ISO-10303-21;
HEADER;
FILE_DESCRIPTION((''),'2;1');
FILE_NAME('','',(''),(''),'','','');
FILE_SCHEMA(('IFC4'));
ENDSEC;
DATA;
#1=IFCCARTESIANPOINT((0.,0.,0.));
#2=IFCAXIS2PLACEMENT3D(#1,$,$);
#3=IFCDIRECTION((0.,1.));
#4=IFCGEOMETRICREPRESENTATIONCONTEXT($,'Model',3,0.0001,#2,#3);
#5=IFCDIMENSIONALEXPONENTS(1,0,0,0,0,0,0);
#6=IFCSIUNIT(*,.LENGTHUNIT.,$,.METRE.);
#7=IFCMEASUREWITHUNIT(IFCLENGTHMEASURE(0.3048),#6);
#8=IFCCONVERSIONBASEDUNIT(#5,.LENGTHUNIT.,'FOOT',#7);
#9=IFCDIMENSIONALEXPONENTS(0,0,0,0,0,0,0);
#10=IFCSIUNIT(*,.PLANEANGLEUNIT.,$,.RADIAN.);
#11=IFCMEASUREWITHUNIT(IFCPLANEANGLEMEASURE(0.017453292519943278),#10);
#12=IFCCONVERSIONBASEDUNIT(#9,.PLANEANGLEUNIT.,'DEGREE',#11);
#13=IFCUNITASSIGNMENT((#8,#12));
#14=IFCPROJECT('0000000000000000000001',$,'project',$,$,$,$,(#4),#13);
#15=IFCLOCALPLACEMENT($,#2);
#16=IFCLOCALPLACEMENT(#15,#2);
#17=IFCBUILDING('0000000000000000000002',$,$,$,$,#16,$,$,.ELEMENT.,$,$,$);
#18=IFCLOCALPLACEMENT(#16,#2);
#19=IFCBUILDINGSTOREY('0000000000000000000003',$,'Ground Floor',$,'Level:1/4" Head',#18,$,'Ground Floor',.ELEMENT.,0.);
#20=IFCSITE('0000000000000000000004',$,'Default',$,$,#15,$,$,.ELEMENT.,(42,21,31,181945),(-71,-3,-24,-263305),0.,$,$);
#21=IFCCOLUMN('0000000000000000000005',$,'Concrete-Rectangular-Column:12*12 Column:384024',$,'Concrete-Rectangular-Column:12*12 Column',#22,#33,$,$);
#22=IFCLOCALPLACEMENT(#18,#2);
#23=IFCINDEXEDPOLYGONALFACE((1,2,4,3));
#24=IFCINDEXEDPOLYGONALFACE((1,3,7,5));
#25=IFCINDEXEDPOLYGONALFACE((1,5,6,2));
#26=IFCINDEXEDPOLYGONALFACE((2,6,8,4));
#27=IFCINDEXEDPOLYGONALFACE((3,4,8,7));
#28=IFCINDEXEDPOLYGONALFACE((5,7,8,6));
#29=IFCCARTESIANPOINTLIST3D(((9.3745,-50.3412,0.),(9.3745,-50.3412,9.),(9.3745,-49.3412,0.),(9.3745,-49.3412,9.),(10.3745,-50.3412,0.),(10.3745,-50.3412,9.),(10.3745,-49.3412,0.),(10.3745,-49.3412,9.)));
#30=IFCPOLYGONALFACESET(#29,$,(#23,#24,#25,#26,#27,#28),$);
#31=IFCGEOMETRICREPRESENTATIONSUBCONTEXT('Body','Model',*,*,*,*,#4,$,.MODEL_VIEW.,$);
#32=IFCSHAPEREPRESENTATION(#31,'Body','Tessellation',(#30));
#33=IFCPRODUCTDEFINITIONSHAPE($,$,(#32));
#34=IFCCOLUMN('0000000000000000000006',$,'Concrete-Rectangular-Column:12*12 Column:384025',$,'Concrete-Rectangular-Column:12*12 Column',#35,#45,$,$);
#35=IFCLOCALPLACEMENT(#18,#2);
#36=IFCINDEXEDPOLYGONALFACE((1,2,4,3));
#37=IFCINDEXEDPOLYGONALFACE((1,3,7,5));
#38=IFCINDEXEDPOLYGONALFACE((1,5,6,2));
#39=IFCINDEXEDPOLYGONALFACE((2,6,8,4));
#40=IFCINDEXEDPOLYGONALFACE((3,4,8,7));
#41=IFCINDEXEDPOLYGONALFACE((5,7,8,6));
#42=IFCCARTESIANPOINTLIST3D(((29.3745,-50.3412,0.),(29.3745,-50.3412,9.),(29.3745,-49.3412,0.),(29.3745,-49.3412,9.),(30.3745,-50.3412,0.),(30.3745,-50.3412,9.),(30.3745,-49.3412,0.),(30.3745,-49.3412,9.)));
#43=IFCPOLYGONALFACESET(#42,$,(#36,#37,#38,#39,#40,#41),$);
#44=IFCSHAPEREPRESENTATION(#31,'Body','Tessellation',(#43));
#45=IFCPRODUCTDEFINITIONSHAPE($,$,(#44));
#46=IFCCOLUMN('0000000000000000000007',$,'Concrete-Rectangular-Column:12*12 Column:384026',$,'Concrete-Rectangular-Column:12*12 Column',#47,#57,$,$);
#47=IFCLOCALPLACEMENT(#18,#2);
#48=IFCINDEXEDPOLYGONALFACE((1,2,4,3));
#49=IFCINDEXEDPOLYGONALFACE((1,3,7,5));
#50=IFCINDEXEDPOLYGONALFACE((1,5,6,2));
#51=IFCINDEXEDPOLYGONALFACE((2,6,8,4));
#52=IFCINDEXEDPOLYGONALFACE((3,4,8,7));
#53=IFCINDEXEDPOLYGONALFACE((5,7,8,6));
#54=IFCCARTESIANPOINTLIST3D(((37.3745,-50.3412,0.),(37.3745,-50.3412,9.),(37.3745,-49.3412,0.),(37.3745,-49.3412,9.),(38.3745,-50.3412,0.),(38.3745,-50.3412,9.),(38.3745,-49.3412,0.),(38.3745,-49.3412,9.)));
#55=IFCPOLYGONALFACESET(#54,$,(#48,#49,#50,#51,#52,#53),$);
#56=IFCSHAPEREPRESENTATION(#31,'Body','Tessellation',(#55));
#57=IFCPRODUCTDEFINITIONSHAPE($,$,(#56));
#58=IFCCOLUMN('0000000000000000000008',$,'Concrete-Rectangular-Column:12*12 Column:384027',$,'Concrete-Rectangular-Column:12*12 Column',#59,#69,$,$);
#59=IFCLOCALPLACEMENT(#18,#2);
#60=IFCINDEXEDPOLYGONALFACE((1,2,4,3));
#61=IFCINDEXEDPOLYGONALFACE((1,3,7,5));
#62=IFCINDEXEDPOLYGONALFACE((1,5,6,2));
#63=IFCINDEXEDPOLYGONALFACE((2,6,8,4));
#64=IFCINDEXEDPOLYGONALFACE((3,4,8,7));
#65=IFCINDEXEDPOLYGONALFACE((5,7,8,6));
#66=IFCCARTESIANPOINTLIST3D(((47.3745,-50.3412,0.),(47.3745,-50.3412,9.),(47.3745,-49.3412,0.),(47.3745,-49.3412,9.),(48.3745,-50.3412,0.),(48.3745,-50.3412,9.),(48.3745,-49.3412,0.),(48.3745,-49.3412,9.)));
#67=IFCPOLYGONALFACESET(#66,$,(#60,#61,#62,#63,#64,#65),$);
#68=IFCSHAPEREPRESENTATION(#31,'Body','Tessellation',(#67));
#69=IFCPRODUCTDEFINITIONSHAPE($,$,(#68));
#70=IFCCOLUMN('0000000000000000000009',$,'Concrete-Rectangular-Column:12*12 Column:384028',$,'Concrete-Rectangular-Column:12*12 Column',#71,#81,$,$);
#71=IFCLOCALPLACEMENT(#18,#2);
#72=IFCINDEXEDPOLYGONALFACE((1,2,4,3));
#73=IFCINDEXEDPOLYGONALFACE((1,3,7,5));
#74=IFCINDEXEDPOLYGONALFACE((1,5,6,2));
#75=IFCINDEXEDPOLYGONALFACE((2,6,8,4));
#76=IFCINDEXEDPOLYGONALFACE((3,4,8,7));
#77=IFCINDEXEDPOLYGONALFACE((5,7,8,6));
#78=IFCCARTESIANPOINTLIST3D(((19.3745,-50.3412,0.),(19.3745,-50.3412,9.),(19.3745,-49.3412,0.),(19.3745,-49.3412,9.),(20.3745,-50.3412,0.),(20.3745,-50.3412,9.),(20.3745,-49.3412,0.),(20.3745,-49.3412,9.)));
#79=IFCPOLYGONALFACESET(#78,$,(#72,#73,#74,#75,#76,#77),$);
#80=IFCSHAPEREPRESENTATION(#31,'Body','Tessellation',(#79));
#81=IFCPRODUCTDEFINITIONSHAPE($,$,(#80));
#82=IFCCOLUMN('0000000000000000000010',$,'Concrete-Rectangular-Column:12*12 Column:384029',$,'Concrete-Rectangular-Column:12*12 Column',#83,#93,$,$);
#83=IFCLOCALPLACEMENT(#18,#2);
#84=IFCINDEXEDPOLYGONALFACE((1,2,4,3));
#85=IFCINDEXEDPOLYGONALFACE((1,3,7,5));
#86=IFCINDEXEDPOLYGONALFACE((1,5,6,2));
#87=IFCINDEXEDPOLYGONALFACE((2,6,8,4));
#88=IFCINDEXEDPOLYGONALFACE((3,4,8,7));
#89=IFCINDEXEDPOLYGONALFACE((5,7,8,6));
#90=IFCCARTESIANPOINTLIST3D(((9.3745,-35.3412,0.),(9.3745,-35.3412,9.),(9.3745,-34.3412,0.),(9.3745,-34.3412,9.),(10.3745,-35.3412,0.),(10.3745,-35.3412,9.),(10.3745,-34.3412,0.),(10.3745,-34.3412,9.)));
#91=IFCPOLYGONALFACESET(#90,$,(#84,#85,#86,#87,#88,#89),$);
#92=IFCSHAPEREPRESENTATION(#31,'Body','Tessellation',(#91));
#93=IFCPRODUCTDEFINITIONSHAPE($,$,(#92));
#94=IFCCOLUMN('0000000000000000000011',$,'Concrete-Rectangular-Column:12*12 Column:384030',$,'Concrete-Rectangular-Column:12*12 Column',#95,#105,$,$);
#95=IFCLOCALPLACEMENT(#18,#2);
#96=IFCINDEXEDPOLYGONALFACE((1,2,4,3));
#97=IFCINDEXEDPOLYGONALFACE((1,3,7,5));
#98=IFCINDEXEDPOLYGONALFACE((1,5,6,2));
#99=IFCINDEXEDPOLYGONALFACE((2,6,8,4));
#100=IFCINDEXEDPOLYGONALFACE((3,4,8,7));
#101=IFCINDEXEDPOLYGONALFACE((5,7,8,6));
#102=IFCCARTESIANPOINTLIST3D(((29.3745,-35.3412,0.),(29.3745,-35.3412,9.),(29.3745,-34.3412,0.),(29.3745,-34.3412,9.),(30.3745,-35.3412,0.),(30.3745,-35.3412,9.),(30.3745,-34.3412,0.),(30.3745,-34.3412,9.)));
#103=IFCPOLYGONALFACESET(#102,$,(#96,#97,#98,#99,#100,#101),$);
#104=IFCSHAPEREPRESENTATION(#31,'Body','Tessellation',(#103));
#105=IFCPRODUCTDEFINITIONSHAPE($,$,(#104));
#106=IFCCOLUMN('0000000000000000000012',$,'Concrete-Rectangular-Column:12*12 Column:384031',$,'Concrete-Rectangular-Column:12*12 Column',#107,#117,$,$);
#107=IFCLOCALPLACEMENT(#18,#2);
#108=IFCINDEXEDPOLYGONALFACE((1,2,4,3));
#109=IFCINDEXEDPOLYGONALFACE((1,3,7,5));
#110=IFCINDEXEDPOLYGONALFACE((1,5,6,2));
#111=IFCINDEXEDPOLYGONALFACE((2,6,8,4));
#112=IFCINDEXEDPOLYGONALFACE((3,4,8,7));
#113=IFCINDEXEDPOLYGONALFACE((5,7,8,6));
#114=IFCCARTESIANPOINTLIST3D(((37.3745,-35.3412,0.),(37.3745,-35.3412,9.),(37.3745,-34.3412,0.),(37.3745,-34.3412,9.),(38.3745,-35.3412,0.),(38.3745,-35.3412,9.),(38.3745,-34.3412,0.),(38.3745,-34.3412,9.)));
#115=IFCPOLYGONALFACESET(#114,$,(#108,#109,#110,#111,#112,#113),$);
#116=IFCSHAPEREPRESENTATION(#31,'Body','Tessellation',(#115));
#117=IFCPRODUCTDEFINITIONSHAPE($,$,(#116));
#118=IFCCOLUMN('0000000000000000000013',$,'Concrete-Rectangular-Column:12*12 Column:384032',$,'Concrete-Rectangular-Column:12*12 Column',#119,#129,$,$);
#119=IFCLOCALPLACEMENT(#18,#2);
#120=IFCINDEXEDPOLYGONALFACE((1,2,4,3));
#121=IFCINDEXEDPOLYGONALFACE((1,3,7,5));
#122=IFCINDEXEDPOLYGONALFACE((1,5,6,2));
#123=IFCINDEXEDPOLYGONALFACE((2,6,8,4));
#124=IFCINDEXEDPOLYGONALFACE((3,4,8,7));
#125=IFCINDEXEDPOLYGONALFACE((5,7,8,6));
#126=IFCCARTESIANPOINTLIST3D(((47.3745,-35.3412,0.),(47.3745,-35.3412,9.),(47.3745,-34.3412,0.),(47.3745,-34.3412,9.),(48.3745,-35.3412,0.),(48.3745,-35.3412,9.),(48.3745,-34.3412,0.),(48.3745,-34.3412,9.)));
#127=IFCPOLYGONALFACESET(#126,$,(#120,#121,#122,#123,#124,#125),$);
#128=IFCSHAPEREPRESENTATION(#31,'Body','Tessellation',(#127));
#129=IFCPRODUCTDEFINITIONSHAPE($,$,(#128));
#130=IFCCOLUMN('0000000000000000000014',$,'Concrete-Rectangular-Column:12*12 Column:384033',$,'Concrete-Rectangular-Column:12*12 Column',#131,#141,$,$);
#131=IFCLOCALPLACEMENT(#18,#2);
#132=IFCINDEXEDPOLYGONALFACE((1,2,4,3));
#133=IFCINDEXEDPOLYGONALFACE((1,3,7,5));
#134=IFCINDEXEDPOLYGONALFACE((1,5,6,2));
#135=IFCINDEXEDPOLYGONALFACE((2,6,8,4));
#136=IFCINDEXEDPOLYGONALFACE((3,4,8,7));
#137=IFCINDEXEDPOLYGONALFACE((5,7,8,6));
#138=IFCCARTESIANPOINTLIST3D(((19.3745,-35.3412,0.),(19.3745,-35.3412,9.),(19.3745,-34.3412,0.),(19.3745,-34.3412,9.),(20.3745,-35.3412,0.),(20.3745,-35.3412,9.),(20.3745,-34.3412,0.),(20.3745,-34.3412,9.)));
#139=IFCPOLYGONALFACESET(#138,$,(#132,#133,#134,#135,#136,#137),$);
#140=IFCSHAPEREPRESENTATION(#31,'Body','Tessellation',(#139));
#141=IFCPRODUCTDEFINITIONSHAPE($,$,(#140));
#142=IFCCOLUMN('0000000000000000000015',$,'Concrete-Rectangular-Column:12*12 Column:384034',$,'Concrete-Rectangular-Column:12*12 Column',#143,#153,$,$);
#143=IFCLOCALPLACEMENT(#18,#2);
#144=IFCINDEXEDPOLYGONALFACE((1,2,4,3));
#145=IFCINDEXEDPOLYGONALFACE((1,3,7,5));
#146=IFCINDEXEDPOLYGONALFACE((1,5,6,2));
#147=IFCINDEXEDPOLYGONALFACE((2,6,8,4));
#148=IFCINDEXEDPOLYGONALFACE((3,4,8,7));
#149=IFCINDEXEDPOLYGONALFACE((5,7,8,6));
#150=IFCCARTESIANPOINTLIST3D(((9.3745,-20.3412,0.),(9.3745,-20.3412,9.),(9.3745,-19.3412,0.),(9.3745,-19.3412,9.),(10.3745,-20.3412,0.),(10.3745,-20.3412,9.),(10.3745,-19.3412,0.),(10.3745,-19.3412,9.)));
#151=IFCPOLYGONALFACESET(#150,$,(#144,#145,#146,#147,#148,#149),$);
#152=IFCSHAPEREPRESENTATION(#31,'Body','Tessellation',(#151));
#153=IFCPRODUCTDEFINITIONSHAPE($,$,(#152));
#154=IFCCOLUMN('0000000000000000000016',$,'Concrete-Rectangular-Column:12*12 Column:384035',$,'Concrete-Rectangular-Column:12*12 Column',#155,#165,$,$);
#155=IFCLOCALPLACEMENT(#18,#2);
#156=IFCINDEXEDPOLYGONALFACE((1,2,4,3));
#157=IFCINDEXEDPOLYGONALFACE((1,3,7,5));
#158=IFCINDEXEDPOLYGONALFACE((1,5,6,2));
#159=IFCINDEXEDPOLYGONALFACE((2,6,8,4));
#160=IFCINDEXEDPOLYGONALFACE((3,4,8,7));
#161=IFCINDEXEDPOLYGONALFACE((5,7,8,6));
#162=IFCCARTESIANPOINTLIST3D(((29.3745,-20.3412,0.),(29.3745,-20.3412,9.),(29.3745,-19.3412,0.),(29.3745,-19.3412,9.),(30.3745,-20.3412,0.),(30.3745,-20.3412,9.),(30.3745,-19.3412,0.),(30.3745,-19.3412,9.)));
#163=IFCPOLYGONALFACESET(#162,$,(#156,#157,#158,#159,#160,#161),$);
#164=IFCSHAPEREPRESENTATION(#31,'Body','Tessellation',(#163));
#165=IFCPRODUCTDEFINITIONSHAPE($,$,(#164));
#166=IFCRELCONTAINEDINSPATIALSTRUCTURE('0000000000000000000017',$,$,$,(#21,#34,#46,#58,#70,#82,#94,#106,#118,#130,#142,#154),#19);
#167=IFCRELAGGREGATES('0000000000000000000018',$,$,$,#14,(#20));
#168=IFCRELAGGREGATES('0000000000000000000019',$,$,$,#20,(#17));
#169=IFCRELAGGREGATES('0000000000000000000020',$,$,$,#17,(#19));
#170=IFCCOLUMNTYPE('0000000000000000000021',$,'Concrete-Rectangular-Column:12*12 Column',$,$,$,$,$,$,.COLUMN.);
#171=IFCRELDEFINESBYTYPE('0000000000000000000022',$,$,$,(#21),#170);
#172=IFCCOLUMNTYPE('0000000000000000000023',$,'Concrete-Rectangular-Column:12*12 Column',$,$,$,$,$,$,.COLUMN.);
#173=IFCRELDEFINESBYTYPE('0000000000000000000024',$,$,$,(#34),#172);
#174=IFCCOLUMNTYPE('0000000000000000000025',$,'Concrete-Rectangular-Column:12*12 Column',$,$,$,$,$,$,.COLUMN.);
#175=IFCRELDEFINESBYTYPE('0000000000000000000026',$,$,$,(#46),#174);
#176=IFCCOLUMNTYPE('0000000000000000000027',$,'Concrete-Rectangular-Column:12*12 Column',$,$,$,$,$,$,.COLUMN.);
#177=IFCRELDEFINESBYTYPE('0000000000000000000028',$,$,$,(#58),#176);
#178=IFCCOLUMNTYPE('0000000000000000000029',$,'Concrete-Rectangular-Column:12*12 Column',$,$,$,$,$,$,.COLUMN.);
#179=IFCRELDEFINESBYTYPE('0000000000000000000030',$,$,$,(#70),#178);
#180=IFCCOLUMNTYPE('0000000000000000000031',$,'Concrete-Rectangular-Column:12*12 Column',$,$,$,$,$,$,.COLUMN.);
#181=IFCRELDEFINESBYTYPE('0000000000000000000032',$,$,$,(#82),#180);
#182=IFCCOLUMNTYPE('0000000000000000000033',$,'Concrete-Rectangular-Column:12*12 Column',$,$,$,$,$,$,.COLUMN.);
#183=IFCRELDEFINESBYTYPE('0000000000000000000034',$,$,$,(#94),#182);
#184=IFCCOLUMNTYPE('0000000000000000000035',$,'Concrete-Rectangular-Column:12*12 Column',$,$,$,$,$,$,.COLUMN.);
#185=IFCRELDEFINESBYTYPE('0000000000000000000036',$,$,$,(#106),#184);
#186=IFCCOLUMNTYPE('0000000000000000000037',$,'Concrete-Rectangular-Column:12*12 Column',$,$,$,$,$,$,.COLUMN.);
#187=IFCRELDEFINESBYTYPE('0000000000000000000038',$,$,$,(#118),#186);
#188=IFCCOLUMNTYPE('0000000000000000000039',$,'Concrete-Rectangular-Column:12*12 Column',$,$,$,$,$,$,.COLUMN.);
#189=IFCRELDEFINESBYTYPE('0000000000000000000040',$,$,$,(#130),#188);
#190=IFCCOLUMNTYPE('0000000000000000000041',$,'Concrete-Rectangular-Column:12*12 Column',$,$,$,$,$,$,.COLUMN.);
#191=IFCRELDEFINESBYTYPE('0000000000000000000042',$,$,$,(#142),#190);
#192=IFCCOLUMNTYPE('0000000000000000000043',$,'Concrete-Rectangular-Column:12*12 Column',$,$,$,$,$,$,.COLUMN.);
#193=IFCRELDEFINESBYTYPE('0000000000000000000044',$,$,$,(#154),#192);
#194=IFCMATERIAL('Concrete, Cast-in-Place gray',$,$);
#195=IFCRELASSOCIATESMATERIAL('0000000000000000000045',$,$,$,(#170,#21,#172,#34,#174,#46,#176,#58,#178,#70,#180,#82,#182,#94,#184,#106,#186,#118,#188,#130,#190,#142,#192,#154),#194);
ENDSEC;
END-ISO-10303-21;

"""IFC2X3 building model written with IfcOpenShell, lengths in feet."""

from ifc_helpers import new_model, entity, si_unit, converted_unit, direction, frame, frame_2d, origin, origin_2d_with_axis, place, context, subcontext, project, spatial, rectangle, extrude, source, transform, mapped, material, type_object, type_shapes, element, save


model = new_model("IFC2X3")

# Units and contexts
model_context = context("Model", 3, precision=0.0001, world=origin(), true_north=direction((0.0, 1.0)))
body_context = subcontext(model_context, "Body", "Model", "MODEL_VIEW")
ifc_project = project(units=[converted_unit("LENGTHUNIT", "FOOT", entity("IfcLengthMeasure", 0.3048), si_unit("LENGTHUNIT", "METRE"), dimensions=[1, 0, 0, 0, 0, 0, 0]), converted_unit("PLANEANGLEUNIT", "DEGREE", entity("IfcPlaneAngleMeasure", 0.017453292519943278), si_unit("PLANEANGLEUNIT", "RADIAN"), dimensions=[0, 0, 0, 0, 0, 0, 0])], contexts=[model_context])

# Site, building, storey
site_placement = place(None, origin())
site = spatial("IfcSite", under=ifc_project, at=site_placement, Name="Default", CompositionType="ELEMENT", RefLatitude=(42, 21, 31, 181945), RefLongitude=(-71, -3, -24, -263305), RefElevation=0.0)
building_placement = place(site_placement, origin())
building = spatial("IfcBuilding", under=site, at=building_placement, CompositionType="ELEMENT")
storey_placement = place(building_placement, origin())
storey = spatial("IfcBuildingStorey", under=building, at=storey_placement, Name="Ground Floor", ObjectType="Level:1/4\" Head", LongName="Ground Floor", CompositionType="ELEMENT", Elevation=0.0)

# Columns
ifc_material_1 = material(Name="Concrete, Cast-in-Place gray")
column_type_1 = type_object("IfcColumnType", Name="Concrete-Rectangular-Column:12*12 Column", PredefinedType="COLUMN", material=ifc_material_1)
shared_shape_1 = source(origin(), body_context, "Body", "SweptSolid", [
    extrude(rectangle(XDim=1.0, YDim=1.0, at=origin_2d_with_axis()), frame((9.8745, -49.8412, 0.0), z_axis=(0.0, 0.0, 1.0), x_axis=(-1.0, 0.0, 0.0)), (0.0, 0.0, 1.0), 9.0),
])
type_shapes(column_type_1, [shared_shape_1])
column_1_placement = place(storey_placement, origin())
element("IfcColumn", 1, at=column_1_placement, inside=storey, type_object=column_type_1, material=ifc_material_1, Name="Concrete-Rectangular-Column:12*12 Column:384024", ObjectType="Concrete-Rectangular-Column:12*12 Column", context=body_context, shape_type="MappedRepresentation", body=[
    mapped(shared_shape_1, transform((0.0, 0.0, 0.0), scale=1.0)),
])
column_type_2 = type_object("IfcColumnType", Name="Concrete-Rectangular-Column:12*12 Column", PredefinedType="COLUMN", material=ifc_material_1)
shared_shape_2 = source(origin(), body_context, "Body", "SweptSolid", [
    extrude(rectangle(XDim=1.0, YDim=1.0, at=frame_2d((0.0, 0.0), x_axis=(1.0, 0.0))), frame((29.8745, -49.8412, 0.0), z_axis=(0.0, 0.0, 1.0), x_axis=(-1.0, 0.0, 0.0)), (0.0, 0.0, 1.0), 9.0),
])
type_shapes(column_type_2, [shared_shape_2])
column_2_placement = place(storey_placement, origin())
element("IfcColumn", 2, at=column_2_placement, inside=storey, type_object=column_type_2, material=ifc_material_1, Name="Concrete-Rectangular-Column:12*12 Column:384025", ObjectType="Concrete-Rectangular-Column:12*12 Column", context=body_context, shape_type="MappedRepresentation", body=[
    mapped(shared_shape_2, transform((0.0, 0.0, 0.0), scale=1.0)),
])
column_type_3 = type_object("IfcColumnType", Name="Concrete-Rectangular-Column:12*12 Column", PredefinedType="COLUMN", material=ifc_material_1)
shared_shape_3 = source(origin(), body_context, "Body", "SweptSolid", [
    extrude(rectangle(XDim=1.0, YDim=1.0, at=origin_2d_with_axis()), frame((37.8745, -49.8412, 0.0), z_axis=(0.0, 0.0, 1.0), x_axis=(-1.0, 0.0, 0.0)), (0.0, 0.0, 1.0), 9.0),
])
type_shapes(column_type_3, [shared_shape_3])
column_3_placement = place(storey_placement, origin())
element("IfcColumn", 3, at=column_3_placement, inside=storey, type_object=column_type_3, material=ifc_material_1, Name="Concrete-Rectangular-Column:12*12 Column:384026", ObjectType="Concrete-Rectangular-Column:12*12 Column", context=body_context, shape_type="MappedRepresentation", body=[
    mapped(shared_shape_3, transform((0.0, 0.0, 0.0), scale=1.0)),
])
column_type_4 = type_object("IfcColumnType", Name="Concrete-Rectangular-Column:12*12 Column", PredefinedType="COLUMN", material=ifc_material_1)
shared_shape_4 = source(origin(), body_context, "Body", "SweptSolid", [
    extrude(rectangle(XDim=1.0, YDim=1.0, at=origin_2d_with_axis()), frame((47.8745, -49.8412, 0.0), z_axis=(0.0, 0.0, 1.0), x_axis=(-1.0, 0.0, 0.0)), (0.0, 0.0, 1.0), 9.0),
])
type_shapes(column_type_4, [shared_shape_4])
column_4_placement = place(storey_placement, origin())
element("IfcColumn", 4, at=column_4_placement, inside=storey, type_object=column_type_4, material=ifc_material_1, Name="Concrete-Rectangular-Column:12*12 Column:384027", ObjectType="Concrete-Rectangular-Column:12*12 Column", context=body_context, shape_type="MappedRepresentation", body=[
    mapped(shared_shape_4, transform((0.0, 0.0, 0.0), scale=1.0)),
])
column_type_5 = type_object("IfcColumnType", Name="Concrete-Rectangular-Column:12*12 Column", PredefinedType="COLUMN", material=ifc_material_1)
shared_shape_5 = source(origin(), body_context, "Body", "SweptSolid", [
    extrude(rectangle(XDim=1.0, YDim=1.0, at=frame_2d((0.0, 0.0), x_axis=(1.0, 0.0))), frame((19.8745, -49.8412, 0.0), z_axis=(0.0, 0.0, 1.0), x_axis=(-1.0, 0.0, 0.0)), (0.0, 0.0, 1.0), 9.0),
])
type_shapes(column_type_5, [shared_shape_5])
column_5_placement = place(storey_placement, origin())
element("IfcColumn", 5, at=column_5_placement, inside=storey, type_object=column_type_5, material=ifc_material_1, Name="Concrete-Rectangular-Column:12*12 Column:384028", ObjectType="Concrete-Rectangular-Column:12*12 Column", context=body_context, shape_type="MappedRepresentation", body=[
    mapped(shared_shape_5, transform((0.0, 0.0, 0.0), scale=1.0)),
])
column_type_6 = type_object("IfcColumnType", Name="Concrete-Rectangular-Column:12*12 Column", PredefinedType="COLUMN", material=ifc_material_1)
shared_shape_6 = source(origin(), body_context, "Body", "SweptSolid", [
    extrude(rectangle(XDim=1.0, YDim=1.0, at=origin_2d_with_axis()), frame((9.8745, -34.8412, 0.0), z_axis=(0.0, 0.0, 1.0), x_axis=(-1.0, 0.0, 0.0)), (0.0, 0.0, 1.0), 9.0),
])
type_shapes(column_type_6, [shared_shape_6])
column_6_placement = place(storey_placement, origin())
element("IfcColumn", 6, at=column_6_placement, inside=storey, type_object=column_type_6, material=ifc_material_1, Name="Concrete-Rectangular-Column:12*12 Column:384029", ObjectType="Concrete-Rectangular-Column:12*12 Column", context=body_context, shape_type="MappedRepresentation", body=[
    mapped(shared_shape_6, transform((0.0, 0.0, 0.0), scale=1.0)),
])
column_type_7 = type_object("IfcColumnType", Name="Concrete-Rectangular-Column:12*12 Column", PredefinedType="COLUMN", material=ifc_material_1)
shared_shape_7 = source(origin(), body_context, "Body", "SweptSolid", [
    extrude(rectangle(XDim=1.0, YDim=1.0, at=frame_2d((0.0, 0.0), x_axis=(1.0, 0.0))), frame((29.8745, -34.8412, 0.0), z_axis=(0.0, 0.0, 1.0), x_axis=(-1.0, 0.0, 0.0)), (0.0, 0.0, 1.0), 9.0),
])
type_shapes(column_type_7, [shared_shape_7])
column_7_placement = place(storey_placement, origin())
element("IfcColumn", 7, at=column_7_placement, inside=storey, type_object=column_type_7, material=ifc_material_1, Name="Concrete-Rectangular-Column:12*12 Column:384030", ObjectType="Concrete-Rectangular-Column:12*12 Column", context=body_context, shape_type="MappedRepresentation", body=[
    mapped(shared_shape_7, transform((0.0, 0.0, 0.0), scale=1.0)),
])
column_type_8 = type_object("IfcColumnType", Name="Concrete-Rectangular-Column:12*12 Column", PredefinedType="COLUMN", material=ifc_material_1)
shared_shape_8 = source(origin(), body_context, "Body", "SweptSolid", [
    extrude(rectangle(XDim=1.0, YDim=1.0, at=origin_2d_with_axis()), frame((37.8745, -34.8412, 0.0), z_axis=(0.0, 0.0, 1.0), x_axis=(-1.0, 0.0, 0.0)), (0.0, 0.0, 1.0), 9.0),
])
type_shapes(column_type_8, [shared_shape_8])
column_8_placement = place(storey_placement, origin())
element("IfcColumn", 8, at=column_8_placement, inside=storey, type_object=column_type_8, material=ifc_material_1, Name="Concrete-Rectangular-Column:12*12 Column:384031", ObjectType="Concrete-Rectangular-Column:12*12 Column", context=body_context, shape_type="MappedRepresentation", body=[
    mapped(shared_shape_8, transform((0.0, 0.0, 0.0), scale=1.0)),
])
column_type_9 = type_object("IfcColumnType", Name="Concrete-Rectangular-Column:12*12 Column", PredefinedType="COLUMN", material=ifc_material_1)
shared_shape_9 = source(origin(), body_context, "Body", "SweptSolid", [
    extrude(rectangle(XDim=1.0, YDim=1.0, at=origin_2d_with_axis()), frame((47.8745, -34.8412, 0.0), z_axis=(0.0, 0.0, 1.0), x_axis=(-1.0, 0.0, 0.0)), (0.0, 0.0, 1.0), 9.0),
])
type_shapes(column_type_9, [shared_shape_9])
column_9_placement = place(storey_placement, origin())
element("IfcColumn", 9, at=column_9_placement, inside=storey, type_object=column_type_9, material=ifc_material_1, Name="Concrete-Rectangular-Column:12*12 Column:384032", ObjectType="Concrete-Rectangular-Column:12*12 Column", context=body_context, shape_type="MappedRepresentation", body=[
    mapped(shared_shape_9, transform((0.0, 0.0, 0.0), scale=1.0)),
])
column_type_10 = type_object("IfcColumnType", Name="Concrete-Rectangular-Column:12*12 Column", PredefinedType="COLUMN", material=ifc_material_1)
shared_shape_10 = source(origin(), body_context, "Body", "SweptSolid", [
    extrude(rectangle(XDim=1.0, YDim=1.0, at=frame_2d((0.0, 0.0), x_axis=(1.0, 0.0))), frame((19.8745, -34.8412, 0.0), z_axis=(0.0, 0.0, 1.0), x_axis=(-1.0, 0.0, 0.0)), (0.0, 0.0, 1.0), 9.0),
])
type_shapes(column_type_10, [shared_shape_10])
column_10_placement = place(storey_placement, origin())
element("IfcColumn", 10, at=column_10_placement, inside=storey, type_object=column_type_10, material=ifc_material_1, Name="Concrete-Rectangular-Column:12*12 Column:384033", ObjectType="Concrete-Rectangular-Column:12*12 Column", context=body_context, shape_type="MappedRepresentation", body=[
    mapped(shared_shape_10, transform((0.0, 0.0, 0.0), scale=1.0)),
])
column_type_11 = type_object("IfcColumnType", Name="Concrete-Rectangular-Column:12*12 Column", PredefinedType="COLUMN", material=ifc_material_1)
shared_shape_11 = source(origin(), body_context, "Body", "SweptSolid", [
    extrude(rectangle(XDim=1.0, YDim=1.0, at=frame_2d((0.0, 0.0), x_axis=(1.0, 0.0))), frame((9.8745, -19.8412, 0.0), z_axis=(0.0, 0.0, 1.0), x_axis=(-1.0, 0.0, 0.0)), (0.0, 0.0, 1.0), 9.0),
])
type_shapes(column_type_11, [shared_shape_11])
column_11_placement = place(storey_placement, origin())
element("IfcColumn", 11, at=column_11_placement, inside=storey, type_object=column_type_11, material=ifc_material_1, Name="Concrete-Rectangular-Column:12*12 Column:384034", ObjectType="Concrete-Rectangular-Column:12*12 Column", context=body_context, shape_type="MappedRepresentation", body=[
    mapped(shared_shape_11, transform((0.0, 0.0, 0.0), scale=1.0)),
])
column_type_12 = type_object("IfcColumnType", Name="Concrete-Rectangular-Column:12*12 Column", PredefinedType="COLUMN", material=ifc_material_1)
shared_shape_12 = source(origin(), body_context, "Body", "SweptSolid", [
    extrude(rectangle(XDim=1.0, YDim=1.0, at=frame_2d((0.0, 0.0), x_axis=(1.0, 0.0))), frame((29.8745, -19.8412, 0.0), z_axis=(0.0, 0.0, 1.0), x_axis=(-1.0, 0.0, 0.0)), (0.0, 0.0, 1.0), 9.0),
])
type_shapes(column_type_12, [shared_shape_12])
column_12_placement = place(storey_placement, origin())
element("IfcColumn", 12, at=column_12_placement, inside=storey, type_object=column_type_12, material=ifc_material_1, Name="Concrete-Rectangular-Column:12*12 Column:384035", ObjectType="Concrete-Rectangular-Column:12*12 Column", context=body_context, shape_type="MappedRepresentation", body=[
    mapped(shared_shape_12, transform((0.0, 0.0, 0.0), scale=1.0)),
])

save(model, "model.ifc")
